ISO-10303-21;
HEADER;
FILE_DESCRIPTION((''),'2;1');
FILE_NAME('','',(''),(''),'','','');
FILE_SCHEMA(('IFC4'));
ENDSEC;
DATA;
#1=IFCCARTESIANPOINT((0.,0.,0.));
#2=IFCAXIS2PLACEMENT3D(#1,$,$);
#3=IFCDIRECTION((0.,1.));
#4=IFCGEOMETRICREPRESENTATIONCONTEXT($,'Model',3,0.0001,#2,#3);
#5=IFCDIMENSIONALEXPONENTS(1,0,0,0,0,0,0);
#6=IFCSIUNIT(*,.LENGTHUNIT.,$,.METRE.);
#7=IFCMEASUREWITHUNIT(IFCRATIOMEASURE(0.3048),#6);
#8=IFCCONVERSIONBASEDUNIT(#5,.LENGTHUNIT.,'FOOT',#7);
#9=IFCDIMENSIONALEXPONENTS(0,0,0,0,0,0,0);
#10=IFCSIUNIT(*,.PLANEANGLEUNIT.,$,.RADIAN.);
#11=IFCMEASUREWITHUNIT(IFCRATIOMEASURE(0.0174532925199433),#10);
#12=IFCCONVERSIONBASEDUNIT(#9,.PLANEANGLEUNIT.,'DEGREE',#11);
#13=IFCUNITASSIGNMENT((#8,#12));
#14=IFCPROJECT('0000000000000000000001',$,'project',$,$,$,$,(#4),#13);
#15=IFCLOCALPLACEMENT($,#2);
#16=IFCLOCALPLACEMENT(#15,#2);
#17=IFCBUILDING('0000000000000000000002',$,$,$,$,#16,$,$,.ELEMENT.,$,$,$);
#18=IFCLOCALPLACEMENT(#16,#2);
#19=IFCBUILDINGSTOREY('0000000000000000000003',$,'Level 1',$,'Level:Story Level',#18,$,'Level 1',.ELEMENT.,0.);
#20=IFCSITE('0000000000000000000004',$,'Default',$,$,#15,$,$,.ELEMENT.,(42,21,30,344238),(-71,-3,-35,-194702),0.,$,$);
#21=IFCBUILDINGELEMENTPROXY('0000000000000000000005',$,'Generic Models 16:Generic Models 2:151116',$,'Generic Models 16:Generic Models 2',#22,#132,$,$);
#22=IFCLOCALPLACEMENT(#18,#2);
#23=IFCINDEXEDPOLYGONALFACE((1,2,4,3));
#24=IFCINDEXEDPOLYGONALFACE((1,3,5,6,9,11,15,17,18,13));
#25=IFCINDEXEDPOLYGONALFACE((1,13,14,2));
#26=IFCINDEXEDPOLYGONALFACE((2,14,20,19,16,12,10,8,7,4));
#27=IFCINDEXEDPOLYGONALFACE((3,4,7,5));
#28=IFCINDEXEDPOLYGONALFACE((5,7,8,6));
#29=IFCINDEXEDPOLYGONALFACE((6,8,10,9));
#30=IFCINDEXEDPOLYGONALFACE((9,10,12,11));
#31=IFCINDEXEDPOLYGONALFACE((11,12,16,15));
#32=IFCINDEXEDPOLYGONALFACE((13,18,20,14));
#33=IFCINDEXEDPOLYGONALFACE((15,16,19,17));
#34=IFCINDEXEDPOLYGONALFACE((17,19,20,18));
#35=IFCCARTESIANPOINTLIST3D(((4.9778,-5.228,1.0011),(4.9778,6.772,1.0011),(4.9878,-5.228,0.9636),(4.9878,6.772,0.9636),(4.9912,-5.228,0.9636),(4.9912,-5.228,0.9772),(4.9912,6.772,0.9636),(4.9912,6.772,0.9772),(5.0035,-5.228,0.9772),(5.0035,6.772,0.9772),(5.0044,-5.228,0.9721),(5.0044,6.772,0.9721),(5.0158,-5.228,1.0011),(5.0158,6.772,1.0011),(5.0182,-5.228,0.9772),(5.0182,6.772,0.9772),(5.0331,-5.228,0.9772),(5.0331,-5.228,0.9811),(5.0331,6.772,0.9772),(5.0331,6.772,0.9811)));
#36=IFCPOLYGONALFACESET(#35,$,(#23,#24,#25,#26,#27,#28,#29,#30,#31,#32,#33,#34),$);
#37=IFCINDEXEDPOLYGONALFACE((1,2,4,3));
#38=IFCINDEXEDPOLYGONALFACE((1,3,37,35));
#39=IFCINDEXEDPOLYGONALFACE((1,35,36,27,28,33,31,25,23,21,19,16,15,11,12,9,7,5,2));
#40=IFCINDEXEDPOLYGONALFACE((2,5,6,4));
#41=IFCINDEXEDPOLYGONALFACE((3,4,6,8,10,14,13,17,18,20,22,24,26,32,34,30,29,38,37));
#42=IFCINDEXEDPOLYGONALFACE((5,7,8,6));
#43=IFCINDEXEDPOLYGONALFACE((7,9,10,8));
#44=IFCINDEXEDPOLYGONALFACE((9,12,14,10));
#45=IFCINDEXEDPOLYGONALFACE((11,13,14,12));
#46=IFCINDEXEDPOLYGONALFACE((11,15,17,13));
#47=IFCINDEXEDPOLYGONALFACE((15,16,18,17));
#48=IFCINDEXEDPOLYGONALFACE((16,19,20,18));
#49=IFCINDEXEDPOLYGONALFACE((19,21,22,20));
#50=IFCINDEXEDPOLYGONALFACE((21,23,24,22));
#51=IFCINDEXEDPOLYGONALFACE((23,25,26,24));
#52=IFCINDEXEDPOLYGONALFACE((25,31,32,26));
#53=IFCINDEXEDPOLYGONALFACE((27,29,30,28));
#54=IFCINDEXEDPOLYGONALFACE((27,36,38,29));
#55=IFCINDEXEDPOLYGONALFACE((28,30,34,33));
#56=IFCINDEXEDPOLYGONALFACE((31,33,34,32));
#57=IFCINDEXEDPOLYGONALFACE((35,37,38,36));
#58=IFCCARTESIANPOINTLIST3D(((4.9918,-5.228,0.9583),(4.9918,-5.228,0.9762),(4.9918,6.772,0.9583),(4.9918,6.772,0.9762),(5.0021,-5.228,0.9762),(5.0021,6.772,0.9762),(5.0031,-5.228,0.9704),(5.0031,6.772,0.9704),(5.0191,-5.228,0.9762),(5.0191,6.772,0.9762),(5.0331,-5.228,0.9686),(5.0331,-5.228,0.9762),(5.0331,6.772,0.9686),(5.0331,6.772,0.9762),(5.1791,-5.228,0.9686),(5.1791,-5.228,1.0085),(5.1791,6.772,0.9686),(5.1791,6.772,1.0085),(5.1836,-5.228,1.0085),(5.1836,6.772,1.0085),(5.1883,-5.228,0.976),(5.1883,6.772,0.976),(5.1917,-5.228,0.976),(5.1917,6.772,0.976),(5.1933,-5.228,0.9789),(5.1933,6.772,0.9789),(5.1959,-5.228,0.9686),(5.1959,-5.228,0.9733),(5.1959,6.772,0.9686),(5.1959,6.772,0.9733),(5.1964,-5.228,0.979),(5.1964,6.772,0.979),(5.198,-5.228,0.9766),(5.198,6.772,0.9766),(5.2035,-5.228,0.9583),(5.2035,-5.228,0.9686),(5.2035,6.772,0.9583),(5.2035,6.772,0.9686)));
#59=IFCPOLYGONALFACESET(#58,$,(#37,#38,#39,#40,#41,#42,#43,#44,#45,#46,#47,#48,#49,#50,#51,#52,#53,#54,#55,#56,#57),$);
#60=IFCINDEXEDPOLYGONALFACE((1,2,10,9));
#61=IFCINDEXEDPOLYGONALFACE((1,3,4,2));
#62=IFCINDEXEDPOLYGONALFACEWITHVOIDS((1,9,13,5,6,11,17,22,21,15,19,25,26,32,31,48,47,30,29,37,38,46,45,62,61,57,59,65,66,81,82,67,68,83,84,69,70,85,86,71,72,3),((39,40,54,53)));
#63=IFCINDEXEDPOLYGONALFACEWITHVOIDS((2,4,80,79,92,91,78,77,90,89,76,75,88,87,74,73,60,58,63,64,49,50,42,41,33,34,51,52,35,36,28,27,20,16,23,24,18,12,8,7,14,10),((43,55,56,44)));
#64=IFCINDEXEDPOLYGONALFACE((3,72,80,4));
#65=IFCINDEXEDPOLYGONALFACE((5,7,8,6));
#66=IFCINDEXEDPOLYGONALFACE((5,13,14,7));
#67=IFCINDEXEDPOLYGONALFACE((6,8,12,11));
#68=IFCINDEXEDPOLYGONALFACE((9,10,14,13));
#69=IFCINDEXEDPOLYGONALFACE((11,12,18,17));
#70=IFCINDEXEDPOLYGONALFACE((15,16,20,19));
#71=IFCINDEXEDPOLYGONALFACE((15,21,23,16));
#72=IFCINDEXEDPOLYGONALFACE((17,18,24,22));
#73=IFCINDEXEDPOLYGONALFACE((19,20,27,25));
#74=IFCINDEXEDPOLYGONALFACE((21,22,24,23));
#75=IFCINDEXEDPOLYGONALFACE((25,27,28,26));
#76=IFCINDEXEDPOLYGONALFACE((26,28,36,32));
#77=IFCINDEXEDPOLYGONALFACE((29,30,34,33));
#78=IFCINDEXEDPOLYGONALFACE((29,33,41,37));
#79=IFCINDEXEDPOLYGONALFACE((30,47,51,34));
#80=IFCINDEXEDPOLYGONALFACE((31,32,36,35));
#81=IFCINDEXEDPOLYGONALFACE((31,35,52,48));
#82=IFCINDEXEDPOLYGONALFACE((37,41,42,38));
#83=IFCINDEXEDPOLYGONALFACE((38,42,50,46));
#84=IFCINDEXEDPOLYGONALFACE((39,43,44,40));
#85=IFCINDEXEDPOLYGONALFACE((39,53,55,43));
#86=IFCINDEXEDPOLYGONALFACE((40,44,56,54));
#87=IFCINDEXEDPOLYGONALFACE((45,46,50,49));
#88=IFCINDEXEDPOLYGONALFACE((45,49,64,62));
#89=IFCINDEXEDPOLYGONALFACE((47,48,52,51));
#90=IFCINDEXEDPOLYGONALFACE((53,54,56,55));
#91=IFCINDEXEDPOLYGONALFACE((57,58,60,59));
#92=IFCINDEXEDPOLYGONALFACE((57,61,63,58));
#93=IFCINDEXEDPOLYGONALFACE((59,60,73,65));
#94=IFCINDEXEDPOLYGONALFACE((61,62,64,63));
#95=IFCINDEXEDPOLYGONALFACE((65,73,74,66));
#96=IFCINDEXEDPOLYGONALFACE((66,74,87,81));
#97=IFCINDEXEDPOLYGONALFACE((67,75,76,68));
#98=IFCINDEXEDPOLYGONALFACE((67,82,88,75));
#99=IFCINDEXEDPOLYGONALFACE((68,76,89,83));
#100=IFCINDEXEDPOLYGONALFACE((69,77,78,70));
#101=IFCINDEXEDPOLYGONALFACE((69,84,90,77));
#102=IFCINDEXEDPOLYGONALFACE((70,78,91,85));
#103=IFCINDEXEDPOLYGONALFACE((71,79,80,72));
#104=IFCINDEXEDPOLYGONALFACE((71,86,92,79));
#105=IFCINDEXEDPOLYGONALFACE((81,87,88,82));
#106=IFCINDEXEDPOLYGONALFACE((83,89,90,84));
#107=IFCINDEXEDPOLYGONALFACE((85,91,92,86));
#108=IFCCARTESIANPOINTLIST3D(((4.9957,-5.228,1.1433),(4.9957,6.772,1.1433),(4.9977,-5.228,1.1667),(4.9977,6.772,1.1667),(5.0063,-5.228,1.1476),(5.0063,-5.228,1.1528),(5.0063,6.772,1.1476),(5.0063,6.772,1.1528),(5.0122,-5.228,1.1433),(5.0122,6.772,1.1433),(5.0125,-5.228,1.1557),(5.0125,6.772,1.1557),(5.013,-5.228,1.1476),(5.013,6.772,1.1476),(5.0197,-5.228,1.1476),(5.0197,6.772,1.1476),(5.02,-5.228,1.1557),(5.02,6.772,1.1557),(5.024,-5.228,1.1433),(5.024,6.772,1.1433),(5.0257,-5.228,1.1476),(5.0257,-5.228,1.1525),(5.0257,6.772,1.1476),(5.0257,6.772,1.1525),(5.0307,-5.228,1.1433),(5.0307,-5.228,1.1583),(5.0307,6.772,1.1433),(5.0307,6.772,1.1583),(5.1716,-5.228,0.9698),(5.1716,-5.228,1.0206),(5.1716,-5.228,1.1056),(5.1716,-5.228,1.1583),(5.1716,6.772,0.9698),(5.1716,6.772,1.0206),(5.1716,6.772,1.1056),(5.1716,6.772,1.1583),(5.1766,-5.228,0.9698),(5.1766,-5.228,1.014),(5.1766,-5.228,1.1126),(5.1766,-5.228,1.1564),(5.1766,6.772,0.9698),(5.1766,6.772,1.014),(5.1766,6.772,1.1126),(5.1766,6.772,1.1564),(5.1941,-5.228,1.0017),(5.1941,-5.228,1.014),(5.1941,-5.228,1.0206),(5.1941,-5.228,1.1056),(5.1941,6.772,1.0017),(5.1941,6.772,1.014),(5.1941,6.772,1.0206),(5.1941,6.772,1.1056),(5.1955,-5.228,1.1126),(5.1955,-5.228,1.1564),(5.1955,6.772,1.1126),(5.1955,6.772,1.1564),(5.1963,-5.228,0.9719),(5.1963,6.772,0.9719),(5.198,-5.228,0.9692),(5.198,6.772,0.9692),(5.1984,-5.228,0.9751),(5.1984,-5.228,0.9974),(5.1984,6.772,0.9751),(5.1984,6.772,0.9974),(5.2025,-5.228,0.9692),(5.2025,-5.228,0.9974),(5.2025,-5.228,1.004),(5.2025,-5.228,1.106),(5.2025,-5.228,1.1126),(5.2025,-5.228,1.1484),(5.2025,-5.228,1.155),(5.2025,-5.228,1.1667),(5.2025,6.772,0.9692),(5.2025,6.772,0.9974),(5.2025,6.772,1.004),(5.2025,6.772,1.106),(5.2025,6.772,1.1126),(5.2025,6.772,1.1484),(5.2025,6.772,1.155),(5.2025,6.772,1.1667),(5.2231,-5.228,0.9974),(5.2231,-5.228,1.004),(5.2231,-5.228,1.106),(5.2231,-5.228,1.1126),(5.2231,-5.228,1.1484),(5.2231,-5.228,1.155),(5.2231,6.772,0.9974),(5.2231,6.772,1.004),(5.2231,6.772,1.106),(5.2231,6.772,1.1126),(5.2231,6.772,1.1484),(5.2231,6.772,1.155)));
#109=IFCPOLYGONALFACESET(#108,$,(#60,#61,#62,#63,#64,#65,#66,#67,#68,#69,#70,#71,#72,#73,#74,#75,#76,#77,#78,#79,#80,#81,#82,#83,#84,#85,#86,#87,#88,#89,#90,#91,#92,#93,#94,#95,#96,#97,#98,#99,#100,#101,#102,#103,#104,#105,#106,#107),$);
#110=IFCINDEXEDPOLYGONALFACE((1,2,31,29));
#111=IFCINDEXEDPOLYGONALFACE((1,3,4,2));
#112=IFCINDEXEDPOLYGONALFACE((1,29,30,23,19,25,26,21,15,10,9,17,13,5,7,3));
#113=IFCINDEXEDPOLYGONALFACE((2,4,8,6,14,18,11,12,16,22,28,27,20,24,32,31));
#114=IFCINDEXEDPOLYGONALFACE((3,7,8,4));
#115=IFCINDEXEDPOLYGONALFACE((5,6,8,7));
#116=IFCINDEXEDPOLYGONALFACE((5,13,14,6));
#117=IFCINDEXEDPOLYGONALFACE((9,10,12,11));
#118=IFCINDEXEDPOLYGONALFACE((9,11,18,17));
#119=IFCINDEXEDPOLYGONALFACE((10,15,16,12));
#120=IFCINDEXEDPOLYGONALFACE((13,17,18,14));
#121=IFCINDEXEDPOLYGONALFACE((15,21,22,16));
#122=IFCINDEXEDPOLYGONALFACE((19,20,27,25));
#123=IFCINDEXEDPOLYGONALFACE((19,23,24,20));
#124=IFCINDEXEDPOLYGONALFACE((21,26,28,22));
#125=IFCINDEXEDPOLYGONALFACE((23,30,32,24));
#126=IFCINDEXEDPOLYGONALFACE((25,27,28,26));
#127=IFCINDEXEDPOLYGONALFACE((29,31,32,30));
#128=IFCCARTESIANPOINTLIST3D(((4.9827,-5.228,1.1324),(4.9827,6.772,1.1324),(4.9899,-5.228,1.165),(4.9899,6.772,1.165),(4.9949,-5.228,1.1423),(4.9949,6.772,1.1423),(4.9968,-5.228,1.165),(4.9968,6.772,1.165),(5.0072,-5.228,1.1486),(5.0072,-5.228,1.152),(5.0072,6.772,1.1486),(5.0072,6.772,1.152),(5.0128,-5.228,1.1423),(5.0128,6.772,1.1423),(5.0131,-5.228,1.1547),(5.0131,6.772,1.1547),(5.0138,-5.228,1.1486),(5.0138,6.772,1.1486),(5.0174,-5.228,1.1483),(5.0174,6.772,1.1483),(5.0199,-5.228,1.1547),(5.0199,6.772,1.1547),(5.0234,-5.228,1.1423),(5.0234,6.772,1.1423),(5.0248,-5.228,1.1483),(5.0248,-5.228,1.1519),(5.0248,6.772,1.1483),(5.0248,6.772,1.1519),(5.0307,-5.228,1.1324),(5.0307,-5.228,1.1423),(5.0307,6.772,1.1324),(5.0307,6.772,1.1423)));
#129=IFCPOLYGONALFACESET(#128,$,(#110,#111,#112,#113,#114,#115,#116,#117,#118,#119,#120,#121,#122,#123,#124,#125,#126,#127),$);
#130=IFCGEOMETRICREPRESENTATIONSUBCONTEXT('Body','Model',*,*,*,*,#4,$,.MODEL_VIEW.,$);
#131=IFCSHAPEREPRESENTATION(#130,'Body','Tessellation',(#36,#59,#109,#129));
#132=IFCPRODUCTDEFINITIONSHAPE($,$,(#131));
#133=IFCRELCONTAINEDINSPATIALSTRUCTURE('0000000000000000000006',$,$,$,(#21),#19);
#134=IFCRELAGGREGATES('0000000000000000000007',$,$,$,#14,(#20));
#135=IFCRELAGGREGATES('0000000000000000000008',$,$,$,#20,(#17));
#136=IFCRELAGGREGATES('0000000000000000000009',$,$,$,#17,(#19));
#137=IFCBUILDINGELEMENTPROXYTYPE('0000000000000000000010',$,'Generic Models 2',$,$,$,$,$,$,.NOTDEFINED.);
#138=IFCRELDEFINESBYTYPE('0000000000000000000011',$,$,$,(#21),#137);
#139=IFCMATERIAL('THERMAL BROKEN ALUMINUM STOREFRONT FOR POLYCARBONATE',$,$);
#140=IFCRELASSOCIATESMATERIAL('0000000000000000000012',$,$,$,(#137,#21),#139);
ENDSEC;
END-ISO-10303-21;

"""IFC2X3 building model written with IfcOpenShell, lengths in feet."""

from ifc_helpers import new_model, entity, si_unit, converted_unit, direction, frame, origin, place, context, subcontext, project, spatial, polyline, outline, extrude, source, transform, mapped, material, type_object, type_shapes, element, save


model = new_model("IFC2X3")

# Units and contexts
model_context = context("Model", 3, precision=0.0001, world=origin(), true_north=direction((0.0, 1.0)))
body_context = subcontext(model_context, "Body", "Model", "MODEL_VIEW")
ifc_project = project(units=[converted_unit("LENGTHUNIT", "FOOT", entity("IfcRatioMeasure", 0.3048), si_unit("LENGTHUNIT", "METRE"), dimensions=[1, 0, 0, 0, 0, 0, 0]), converted_unit("PLANEANGLEUNIT", "DEGREE", entity("IfcRatioMeasure", 0.0174532925199433), si_unit("PLANEANGLEUNIT", "RADIAN"), dimensions=[0, 0, 0, 0, 0, 0, 0])], contexts=[model_context])

# Site, building, storey
site_placement = place(None, origin())
site = spatial("IfcSite", under=ifc_project, at=site_placement, Name="Default", CompositionType="ELEMENT", RefLatitude=(42, 21, 30, 344238), RefLongitude=(-71, -3, -35, -194702), RefElevation=0.0)
building_placement = place(site_placement, origin())
building = spatial("IfcBuilding", under=site, at=building_placement, CompositionType="ELEMENT")
storey_placement = place(building_placement, origin())
storey = spatial("IfcBuildingStorey", under=building, at=storey_placement, Name="Level 1", ObjectType="Level:Story Level", LongName="Level 1", CompositionType="ELEMENT", Elevation=0.0)

# Building element proxy
ifc_material = material(Name="THERMAL BROKEN ALUMINUM STOREFRONT FOR POLYCARBONATE")
building_element_proxy_type_1 = type_object("IfcBuildingElementProxyType", Name="Generic Models 2", PredefinedType="NOTDEFINED", material=ifc_material)
shared_shape_1 = source(origin(), body_context, "Body", "SweptSolid", [
    extrude(outline(polyline([(-0.0104, -0.0212), (0.0284, -0.0212), (0.0186, 0.0156), (-0.0052, 0.0271), (-0.009, 0.026), (-0.0051, 0.0117), (-0.0065, -0.003), (-0.0014, -0.0025), (0.0018, -0.0144), (-0.0113, -0.0179), (-0.0104, -0.0212)])), frame((-15.0475, 0.5792, -0.4887), z_axis=(1.0, 0.0, 0.0), x_axis=(0.0, 0.257663, 0.966235)), (0.0, 0.0, 1.0), 12.0),
    extrude(outline(polyline([(0.068, 0.0006), (0.0711, 0.0006), (0.0726, 0.0031), (0.0702, 0.0064), (0.07, 0.011), (0.0776, 0.0114), (0.0771, 0.0217), (-0.1343, 0.0107), (-0.1334, -0.0072), (-0.1231, -0.0066), (-0.1224, -0.0008), (-0.1062, -0.0058), (-0.0922, -0.005), (-0.0926, 0.0025), (0.0533, 0.0101), (0.0554, -0.0297), (0.0599, -0.0295), (0.0628, 0.0032), (0.0663, 0.0034), (0.068, 0.0006)])), frame((-15.0475, 0.4594, -0.4919), z_axis=(1.0, 0.0, 0.0), x_axis=(0.0, -0.998659, 0.051774)), (0.0, 0.0, 1.0), 12.0),
    extrude(outline(polyline([(-0.073, 0.107), (-0.058, 0.107), (-0.058, 0.1137), (-0.0623, 0.118), (-0.0623, 0.1121), (-0.0672, 0.1121), (-0.0704, 0.1177), (-0.0704, 0.1252), (-0.0675, 0.1315), (-0.0623, 0.1315), (-0.0623, 0.1248), (-0.058, 0.1255), (-0.058, 0.142), (-0.0814, 0.1401), (-0.0814, -0.0647), (-0.0697, -0.0647), (-0.0697, -0.0853), (-0.0631, -0.0853), (-0.0631, -0.0647), (-0.0273, -0.0647), (-0.0273, -0.0853), (-0.0207, -0.0853), (-0.0207, -0.0647), (0.0812, -0.0647), (0.0812, -0.0853), (0.0878, -0.0853), (0.0878, -0.0647), (0.1161, -0.0647), (0.1161, -0.0603), (0.1133, -0.0585), (0.1102, -0.0606), (0.0878, -0.0606), (0.0836, -0.0564), (0.0713, -0.0564), (0.0713, -0.0389), (0.1155, -0.0389), (0.1155, -0.0338), (0.0647, -0.0338), (0.0647, -0.0564), (-0.0203, -0.0564), (-0.0203, -0.0338), (-0.073, -0.0338), (-0.073, 0.107)]), holes=[polyline([(-0.0711, -0.0577), (-0.0711, -0.0389), (-0.0273, -0.0389), (-0.0273, -0.0577), (-0.0711, -0.0577)])]), frame((-15.0475, 0.447, -0.3825), z_axis=(1.0, 0.0, 0.0), x_axis=(0.0, 0.0, -1.0)), (0.0, 0.0, 1.0), 12.0),
    extrude(outline(polyline([(-0.0218, -0.0251), (0.0116, -0.0251), (0.0131, -0.0183), (-0.0094, -0.0153), (-0.0056, 0.0021), (0.0008, 0.0018), (-0.0006, -0.0047), (0.0027, -0.0054), (0.0066, -0.0003), (0.0081, 0.0064), (0.0064, 0.0118), (0.0029, 0.0126), (0.0013, 0.0053), (-0.0032, 0.0125), (-0.0017, 0.0197), (-0.0114, 0.0218), (-0.0218, -0.0251)])), frame((-15.0475, 0.5729, -0.3196), z_axis=(1.0, 0.0, 0.0), x_axis=(0.0, -0.217466, 0.976068)), (0.0, 0.0, 1.0), 12.0),
])
type_shapes(building_element_proxy_type_1, [shared_shape_1])
proxy_1_placement = place(storey_placement, frame((5.5848, 9.8195, 1.4678), z_axis=(0.0, 0.0, 1.0), x_axis=(0.0, 1.0, 0.0)))
element("IfcBuildingElementProxy", 1, at=proxy_1_placement, inside=storey, type_object=building_element_proxy_type_1, material=ifc_material, Name="Generic Models 16:Generic Models 2:151116", ObjectType="Generic Models 16:Generic Models 2", context=body_context, shape_type="MappedRepresentation", body=[
    mapped(shared_shape_1, transform((0.0, 0.0, 0.0), scale=1.0)),
])

save(model, "model.ifc")
